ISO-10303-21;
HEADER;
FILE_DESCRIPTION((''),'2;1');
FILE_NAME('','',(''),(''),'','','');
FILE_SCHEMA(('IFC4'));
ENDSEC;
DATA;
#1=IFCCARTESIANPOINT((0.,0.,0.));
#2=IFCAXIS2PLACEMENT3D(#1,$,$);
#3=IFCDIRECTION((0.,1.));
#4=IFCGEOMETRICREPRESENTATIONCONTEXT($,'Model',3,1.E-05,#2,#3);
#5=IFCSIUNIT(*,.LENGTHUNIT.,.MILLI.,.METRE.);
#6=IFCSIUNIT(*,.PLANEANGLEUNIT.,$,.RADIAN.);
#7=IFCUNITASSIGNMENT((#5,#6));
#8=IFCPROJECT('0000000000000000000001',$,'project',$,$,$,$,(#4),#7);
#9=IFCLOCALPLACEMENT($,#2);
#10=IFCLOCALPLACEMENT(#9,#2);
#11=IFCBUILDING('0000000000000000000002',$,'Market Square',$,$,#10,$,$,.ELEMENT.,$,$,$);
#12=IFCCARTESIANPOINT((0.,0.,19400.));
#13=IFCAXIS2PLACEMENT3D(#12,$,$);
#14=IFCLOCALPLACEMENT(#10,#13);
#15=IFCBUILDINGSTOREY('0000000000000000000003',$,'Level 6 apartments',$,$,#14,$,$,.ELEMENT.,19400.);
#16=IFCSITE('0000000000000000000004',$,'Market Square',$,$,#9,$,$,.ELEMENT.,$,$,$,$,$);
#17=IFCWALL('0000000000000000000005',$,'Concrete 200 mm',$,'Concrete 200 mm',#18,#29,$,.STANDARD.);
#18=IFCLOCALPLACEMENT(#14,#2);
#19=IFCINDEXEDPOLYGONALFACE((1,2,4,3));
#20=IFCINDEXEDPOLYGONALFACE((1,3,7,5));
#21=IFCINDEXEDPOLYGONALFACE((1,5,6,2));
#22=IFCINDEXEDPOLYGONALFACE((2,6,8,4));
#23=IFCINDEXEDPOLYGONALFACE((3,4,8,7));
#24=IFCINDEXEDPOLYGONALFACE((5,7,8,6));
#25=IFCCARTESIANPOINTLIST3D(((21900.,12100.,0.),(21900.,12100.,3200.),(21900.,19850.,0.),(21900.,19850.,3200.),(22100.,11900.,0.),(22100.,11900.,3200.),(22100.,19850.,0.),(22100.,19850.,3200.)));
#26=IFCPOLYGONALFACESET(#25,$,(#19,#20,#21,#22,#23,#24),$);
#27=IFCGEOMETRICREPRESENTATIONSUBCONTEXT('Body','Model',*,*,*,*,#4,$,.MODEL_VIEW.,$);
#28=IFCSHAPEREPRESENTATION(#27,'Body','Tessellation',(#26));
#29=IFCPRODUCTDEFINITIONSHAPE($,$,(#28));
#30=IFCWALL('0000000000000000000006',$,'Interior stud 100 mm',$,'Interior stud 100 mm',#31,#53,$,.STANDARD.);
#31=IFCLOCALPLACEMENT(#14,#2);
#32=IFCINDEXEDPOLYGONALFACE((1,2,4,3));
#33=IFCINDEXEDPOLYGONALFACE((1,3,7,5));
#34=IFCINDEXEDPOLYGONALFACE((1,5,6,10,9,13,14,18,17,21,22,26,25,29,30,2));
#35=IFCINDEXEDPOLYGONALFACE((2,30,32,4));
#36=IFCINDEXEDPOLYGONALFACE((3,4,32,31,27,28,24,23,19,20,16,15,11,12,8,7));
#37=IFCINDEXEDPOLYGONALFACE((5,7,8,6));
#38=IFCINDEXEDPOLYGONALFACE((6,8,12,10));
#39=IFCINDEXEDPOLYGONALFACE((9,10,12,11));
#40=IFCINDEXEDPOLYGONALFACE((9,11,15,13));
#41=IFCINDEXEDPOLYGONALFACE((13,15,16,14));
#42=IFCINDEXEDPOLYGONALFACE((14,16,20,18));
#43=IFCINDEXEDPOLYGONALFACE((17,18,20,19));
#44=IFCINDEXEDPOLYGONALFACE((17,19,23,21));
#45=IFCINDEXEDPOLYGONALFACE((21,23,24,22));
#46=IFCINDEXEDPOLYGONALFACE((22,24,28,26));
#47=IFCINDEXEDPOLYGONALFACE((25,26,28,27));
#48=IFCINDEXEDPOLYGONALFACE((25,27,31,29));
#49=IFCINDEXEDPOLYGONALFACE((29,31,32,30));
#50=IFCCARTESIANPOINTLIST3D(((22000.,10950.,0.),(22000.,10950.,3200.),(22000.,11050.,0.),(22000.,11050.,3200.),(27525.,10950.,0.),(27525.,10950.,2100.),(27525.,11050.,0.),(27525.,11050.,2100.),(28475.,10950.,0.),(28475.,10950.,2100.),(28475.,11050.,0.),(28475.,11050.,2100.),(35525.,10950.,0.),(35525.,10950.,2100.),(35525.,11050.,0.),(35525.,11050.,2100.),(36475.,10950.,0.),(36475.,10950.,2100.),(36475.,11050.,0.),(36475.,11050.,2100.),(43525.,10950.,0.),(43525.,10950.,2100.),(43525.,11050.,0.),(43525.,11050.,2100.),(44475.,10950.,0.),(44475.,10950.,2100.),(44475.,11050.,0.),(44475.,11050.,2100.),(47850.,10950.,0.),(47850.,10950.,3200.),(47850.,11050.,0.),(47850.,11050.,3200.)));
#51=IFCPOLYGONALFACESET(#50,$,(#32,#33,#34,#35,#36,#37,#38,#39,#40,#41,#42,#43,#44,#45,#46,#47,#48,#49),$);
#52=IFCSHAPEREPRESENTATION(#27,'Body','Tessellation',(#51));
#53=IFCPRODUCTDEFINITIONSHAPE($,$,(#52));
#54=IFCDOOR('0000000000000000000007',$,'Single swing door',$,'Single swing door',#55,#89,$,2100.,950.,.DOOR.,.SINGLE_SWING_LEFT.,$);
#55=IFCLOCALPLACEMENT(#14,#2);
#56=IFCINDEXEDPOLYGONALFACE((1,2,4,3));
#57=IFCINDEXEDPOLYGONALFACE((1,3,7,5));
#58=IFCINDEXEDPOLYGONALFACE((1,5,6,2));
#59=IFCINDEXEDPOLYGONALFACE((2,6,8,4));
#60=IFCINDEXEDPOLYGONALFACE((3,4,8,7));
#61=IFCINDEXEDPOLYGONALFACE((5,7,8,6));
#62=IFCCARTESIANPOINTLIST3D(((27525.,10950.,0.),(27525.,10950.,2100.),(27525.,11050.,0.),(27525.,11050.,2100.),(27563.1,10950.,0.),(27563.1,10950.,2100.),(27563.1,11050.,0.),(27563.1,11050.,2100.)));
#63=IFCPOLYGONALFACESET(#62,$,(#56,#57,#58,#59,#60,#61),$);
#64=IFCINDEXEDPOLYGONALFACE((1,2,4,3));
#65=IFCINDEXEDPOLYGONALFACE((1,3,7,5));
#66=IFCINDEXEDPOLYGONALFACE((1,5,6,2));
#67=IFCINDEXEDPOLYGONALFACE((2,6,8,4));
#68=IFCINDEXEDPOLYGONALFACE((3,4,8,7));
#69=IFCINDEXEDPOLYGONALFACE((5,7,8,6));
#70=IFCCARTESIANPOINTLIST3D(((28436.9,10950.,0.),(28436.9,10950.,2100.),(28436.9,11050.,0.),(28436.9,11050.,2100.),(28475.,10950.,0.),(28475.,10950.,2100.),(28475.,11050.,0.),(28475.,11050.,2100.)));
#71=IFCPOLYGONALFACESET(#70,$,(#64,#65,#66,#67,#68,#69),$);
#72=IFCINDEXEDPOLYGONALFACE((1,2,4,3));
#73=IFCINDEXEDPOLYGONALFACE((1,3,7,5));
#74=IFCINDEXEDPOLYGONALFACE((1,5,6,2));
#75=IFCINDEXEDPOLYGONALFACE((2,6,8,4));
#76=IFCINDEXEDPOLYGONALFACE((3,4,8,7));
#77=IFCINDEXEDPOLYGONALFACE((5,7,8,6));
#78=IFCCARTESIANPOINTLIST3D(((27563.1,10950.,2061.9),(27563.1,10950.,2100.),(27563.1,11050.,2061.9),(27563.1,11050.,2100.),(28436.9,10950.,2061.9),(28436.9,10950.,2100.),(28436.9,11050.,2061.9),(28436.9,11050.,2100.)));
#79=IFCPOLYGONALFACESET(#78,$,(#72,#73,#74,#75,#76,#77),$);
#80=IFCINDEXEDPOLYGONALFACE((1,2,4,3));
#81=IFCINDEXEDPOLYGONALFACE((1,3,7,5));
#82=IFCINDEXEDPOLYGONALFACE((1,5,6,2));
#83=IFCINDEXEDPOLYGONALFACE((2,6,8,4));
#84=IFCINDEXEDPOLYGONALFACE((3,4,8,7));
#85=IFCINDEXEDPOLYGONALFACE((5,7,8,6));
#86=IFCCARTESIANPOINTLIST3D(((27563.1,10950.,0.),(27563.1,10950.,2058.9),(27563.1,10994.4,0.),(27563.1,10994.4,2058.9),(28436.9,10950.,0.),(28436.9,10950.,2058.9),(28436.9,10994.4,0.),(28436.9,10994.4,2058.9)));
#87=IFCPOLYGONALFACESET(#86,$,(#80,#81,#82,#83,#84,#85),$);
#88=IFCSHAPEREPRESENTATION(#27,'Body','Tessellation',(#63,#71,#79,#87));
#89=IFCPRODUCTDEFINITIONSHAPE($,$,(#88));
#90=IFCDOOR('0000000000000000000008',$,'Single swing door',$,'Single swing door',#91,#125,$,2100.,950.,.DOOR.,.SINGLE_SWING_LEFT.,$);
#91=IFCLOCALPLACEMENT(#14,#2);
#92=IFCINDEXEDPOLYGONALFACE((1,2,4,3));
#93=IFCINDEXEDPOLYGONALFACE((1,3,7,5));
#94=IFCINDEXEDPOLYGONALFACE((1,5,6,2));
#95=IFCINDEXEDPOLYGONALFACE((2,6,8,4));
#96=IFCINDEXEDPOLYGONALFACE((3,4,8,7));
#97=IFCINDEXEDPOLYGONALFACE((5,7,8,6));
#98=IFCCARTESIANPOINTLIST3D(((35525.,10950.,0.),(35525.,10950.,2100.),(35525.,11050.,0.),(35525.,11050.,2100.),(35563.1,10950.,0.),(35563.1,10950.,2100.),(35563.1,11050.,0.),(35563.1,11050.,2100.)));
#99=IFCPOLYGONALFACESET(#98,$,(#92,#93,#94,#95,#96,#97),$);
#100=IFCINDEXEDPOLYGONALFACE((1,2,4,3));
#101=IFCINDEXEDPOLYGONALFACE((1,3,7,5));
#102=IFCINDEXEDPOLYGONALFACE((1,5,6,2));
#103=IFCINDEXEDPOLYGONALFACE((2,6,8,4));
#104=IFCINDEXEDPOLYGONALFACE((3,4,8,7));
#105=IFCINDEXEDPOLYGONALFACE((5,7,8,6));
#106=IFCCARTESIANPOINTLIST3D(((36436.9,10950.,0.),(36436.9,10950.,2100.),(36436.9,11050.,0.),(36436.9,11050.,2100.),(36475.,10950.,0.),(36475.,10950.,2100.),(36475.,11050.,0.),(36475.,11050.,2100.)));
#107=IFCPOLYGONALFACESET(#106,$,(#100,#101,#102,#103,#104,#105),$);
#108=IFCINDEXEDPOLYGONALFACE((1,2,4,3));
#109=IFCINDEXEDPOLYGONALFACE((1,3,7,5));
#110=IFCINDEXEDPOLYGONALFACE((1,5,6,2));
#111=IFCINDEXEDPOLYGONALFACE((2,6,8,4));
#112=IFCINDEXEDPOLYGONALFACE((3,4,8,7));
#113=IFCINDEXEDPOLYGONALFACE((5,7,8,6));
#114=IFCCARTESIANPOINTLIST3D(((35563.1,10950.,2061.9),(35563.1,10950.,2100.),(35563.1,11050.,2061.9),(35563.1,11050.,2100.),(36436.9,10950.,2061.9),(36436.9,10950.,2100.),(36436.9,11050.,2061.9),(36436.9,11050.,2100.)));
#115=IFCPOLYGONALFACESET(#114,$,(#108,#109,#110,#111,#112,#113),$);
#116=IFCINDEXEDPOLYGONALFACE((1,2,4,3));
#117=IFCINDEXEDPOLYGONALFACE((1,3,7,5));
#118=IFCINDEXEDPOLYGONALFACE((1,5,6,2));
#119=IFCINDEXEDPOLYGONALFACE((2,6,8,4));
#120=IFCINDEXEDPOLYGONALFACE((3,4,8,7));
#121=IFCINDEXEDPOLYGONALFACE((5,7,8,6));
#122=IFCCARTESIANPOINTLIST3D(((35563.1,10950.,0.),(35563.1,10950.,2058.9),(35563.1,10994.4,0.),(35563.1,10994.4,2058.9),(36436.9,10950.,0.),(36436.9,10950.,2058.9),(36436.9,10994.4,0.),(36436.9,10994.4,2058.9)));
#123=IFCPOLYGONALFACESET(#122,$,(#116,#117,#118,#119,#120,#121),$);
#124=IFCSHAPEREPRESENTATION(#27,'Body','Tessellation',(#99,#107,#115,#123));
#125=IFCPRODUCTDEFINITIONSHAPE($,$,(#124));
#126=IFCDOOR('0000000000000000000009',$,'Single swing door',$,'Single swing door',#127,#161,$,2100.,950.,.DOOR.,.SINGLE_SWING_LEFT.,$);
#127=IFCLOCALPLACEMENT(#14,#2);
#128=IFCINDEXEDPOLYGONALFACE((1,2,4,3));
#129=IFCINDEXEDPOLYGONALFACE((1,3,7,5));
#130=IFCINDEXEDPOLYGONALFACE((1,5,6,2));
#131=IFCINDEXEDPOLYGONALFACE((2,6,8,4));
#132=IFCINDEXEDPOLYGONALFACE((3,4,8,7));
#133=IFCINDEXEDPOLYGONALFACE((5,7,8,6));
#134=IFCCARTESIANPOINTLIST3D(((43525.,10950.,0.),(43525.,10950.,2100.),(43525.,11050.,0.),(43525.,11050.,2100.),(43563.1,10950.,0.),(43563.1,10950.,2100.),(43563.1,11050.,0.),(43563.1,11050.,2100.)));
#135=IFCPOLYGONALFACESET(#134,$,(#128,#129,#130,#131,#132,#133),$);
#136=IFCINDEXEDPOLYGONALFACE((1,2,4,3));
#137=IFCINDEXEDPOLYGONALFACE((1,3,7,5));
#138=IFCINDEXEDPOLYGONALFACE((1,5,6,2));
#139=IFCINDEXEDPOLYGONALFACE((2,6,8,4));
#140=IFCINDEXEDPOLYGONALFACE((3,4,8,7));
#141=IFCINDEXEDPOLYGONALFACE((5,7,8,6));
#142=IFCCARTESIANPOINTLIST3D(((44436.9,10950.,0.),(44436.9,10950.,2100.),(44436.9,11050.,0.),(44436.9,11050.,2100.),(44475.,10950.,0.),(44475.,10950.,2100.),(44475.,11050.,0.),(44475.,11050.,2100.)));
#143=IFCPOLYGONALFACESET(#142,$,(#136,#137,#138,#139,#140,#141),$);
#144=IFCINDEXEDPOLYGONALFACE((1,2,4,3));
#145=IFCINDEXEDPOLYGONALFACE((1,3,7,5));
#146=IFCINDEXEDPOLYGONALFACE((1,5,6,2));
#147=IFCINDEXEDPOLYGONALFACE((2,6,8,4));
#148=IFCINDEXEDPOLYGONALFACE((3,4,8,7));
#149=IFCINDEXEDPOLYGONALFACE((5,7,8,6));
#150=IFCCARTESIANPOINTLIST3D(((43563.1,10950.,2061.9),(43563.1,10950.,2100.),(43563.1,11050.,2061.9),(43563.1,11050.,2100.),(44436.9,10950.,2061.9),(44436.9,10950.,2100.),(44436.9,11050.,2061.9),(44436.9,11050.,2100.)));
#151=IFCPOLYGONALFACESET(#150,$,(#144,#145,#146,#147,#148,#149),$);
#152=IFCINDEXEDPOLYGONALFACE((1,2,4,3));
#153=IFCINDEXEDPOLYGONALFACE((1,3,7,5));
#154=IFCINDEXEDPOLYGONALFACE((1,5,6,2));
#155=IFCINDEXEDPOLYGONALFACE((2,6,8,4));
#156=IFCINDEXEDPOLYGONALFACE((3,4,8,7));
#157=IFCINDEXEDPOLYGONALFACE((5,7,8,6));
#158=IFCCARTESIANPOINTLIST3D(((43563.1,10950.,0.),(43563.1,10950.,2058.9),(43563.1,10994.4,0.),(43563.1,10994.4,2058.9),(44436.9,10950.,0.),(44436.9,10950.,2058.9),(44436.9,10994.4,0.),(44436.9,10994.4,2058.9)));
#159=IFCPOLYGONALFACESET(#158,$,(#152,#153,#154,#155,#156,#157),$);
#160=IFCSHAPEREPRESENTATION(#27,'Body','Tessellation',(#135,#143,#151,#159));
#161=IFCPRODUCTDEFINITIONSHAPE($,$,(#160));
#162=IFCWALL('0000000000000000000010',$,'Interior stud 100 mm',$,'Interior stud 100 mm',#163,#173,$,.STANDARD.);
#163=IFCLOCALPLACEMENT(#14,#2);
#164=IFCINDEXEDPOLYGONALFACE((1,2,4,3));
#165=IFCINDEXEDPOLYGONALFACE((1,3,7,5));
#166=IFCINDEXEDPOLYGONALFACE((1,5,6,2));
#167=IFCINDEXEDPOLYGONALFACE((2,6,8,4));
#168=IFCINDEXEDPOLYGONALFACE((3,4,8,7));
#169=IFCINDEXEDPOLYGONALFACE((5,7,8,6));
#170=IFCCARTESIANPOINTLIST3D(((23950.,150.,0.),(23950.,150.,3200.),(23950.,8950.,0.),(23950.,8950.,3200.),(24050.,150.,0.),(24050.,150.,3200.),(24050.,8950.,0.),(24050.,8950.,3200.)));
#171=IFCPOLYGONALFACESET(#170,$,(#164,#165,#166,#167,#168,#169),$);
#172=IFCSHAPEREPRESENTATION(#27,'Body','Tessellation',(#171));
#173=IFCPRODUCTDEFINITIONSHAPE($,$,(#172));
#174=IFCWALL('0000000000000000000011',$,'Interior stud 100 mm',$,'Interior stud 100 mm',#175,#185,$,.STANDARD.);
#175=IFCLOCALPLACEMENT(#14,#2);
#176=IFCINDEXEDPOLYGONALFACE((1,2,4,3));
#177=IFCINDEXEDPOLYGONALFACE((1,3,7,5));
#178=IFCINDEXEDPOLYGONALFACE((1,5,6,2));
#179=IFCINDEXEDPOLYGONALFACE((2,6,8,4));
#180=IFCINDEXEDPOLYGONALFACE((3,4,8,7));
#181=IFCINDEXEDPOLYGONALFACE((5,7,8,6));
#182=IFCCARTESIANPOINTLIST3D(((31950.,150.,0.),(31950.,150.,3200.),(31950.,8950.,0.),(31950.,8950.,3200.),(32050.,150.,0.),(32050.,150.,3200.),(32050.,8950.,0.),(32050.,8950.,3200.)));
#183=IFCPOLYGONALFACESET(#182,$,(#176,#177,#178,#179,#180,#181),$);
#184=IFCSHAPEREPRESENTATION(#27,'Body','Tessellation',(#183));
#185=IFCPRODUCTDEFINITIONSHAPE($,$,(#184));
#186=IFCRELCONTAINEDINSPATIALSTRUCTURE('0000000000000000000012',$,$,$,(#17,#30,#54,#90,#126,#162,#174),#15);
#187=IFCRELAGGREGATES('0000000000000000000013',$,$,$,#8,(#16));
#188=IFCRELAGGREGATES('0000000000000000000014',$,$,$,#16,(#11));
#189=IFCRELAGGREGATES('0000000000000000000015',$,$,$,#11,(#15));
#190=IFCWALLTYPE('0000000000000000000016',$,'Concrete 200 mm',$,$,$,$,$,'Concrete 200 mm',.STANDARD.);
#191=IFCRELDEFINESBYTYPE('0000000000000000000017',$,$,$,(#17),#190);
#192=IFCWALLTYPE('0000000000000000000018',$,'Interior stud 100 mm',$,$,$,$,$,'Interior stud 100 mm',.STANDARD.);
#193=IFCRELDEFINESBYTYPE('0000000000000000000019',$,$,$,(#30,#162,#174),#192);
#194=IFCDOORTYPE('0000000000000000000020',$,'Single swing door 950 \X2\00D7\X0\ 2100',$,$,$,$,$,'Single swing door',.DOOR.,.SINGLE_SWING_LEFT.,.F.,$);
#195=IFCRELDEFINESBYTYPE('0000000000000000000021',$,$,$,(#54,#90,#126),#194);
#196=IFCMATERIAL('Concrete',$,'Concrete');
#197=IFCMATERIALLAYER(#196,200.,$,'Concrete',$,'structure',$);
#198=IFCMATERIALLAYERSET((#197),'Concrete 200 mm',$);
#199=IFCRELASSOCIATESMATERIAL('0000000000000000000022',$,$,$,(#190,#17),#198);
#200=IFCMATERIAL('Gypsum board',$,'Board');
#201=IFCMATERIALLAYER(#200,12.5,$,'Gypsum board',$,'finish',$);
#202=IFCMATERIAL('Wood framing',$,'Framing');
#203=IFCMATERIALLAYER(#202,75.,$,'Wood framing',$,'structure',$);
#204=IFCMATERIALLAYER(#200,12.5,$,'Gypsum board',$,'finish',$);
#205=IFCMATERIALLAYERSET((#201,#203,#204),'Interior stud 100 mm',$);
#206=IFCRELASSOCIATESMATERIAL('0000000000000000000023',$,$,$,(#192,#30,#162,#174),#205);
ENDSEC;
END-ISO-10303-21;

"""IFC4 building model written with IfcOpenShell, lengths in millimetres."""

from ifc_helpers import new_model, si_unit, direction, frame, origin, origin_with_axes, place, context, subcontext, project, spatial, polyline, outline, extrude, material, layer, layer_set, layer_usage, type_object, element, fill, save


model = new_model("IFC4")

# Units and contexts
model_context = context("Model", 3, precision=1e-05, world=origin(), true_north=direction((0.0, 1.0)))
body_context = subcontext(model_context, "Body", "Model", "MODEL_VIEW")
ifc_project = project(units=[si_unit("LENGTHUNIT", "METRE", prefix="MILLI"), si_unit("PLANEANGLEUNIT", "RADIAN")], contexts=[model_context])

# Site, building, storey
site_placement = place(None, origin())
site = spatial("IfcSite", under=ifc_project, at=site_placement, Name="Market Square", CompositionType="ELEMENT")
building_placement = place(site_placement, origin())
building = spatial("IfcBuilding", under=site, at=building_placement, Name="Market Square", CompositionType="ELEMENT")
storey_placement = place(building_placement, frame((0.0, 0.0, 19400.0)))
storey = spatial("IfcBuildingStorey", under=building, at=storey_placement, Name="Level 6 apartments", CompositionType="ELEMENT", Elevation=19400.0)

# Wall
ifc_material_1 = material(Name="Concrete", Category="Concrete")
ifc_layer_1 = layer(ifc_material_1, 200.0, Name="Concrete", Category="structure")
ifc_layer_set_1 = layer_set([ifc_layer_1], Name="Concrete 200 mm")
ifc_layer_usage_1 = layer_usage(ifc_layer_set_1, "AXIS2", "NEGATIVE", 100.0)
wall_type_1 = type_object("IfcWallType", Name="Concrete 200 mm", ElementType="Concrete 200 mm", PredefinedType="STANDARD", material=ifc_layer_set_1)
wall_1_placement = place(storey_placement, frame((22000.0, 12000.0, 0.0), z_axis=(0.0, 0.0, 1.0), x_axis=(0.0, 1.0, 0.0)))
element("IfcWall", 1, at=wall_1_placement, inside=storey, type_object=wall_type_1, material=ifc_layer_usage_1, Name="Concrete 200 mm", ObjectType="Concrete 200 mm", PredefinedType="STANDARD", context=body_context, shape_type="SweptSolid", body=[
    extrude(outline(polyline([(-100.0, -100.0), (7850.0, -100.0), (7850.0, 100.0), (100.0, 100.0), (-100.0, -100.0)])), origin(), (0.0, 0.0, 1.0), 3200.0),
])

# Wall, openings, doors
ifc_material_2 = material(Name="Gypsum board", Category="Board")
ifc_layer_2 = layer(ifc_material_2, 12.5, Name="Gypsum board", Category="finish")
ifc_material_3 = material(Name="Wood framing", Category="Framing")
ifc_layer_3 = layer(ifc_material_3, 75.0, Name="Wood framing", Category="structure")
ifc_layer_4 = layer(ifc_material_2, 12.5, Name="Gypsum board", Category="finish")
ifc_layer_set_2 = layer_set([ifc_layer_2, ifc_layer_3, ifc_layer_4], Name="Interior stud 100 mm")
ifc_layer_usage_2 = layer_usage(ifc_layer_set_2, "AXIS2", "NEGATIVE", 50.0)
wall_type_2 = type_object("IfcWallType", Name="Interior stud 100 mm", ElementType="Interior stud 100 mm", PredefinedType="STANDARD", material=ifc_layer_set_2)
wall_2_placement = place(storey_placement, frame((22000.0, 11000.0, 0.0), z_axis=(0.0, 0.0, 1.0), x_axis=(1.0, 0.0, 0.0)))
wall_2 = element("IfcWall", 2, at=wall_2_placement, inside=storey, type_object=wall_type_2, material=ifc_layer_usage_2, Name="Interior stud 100 mm", ObjectType="Interior stud 100 mm", PredefinedType="STANDARD", context=body_context, shape_type="SweptSolid", body=[
    extrude(outline(polyline([(0.0, -50.0), (25850.0, -50.0), (25850.0, 50.0), (0.0, 50.0), (0.0, -50.0)])), origin(), (0.0, 0.0, 1.0), 3200.0),
])
opening_1_placement = place(wall_2_placement, frame((5525.0, 0.0, 0.0), z_axis=(0.0, 0.0, 1.0), x_axis=(1.0, 0.0, 0.0)))
opening_1 = element("IfcOpeningElement", 3, at=opening_1_placement, cuts=wall_2, PredefinedType="OPENING", context=body_context, shape_type="SweptSolid", body=[
    extrude(outline(polyline([(0.0, -60.0), (950.0, -60.0), (950.0, 60.0), (0.0, 60.0), (0.0, -60.0)])), origin(), (0.0, 0.0, 1.0), 2100.0),
])
opening_2_placement = place(wall_2_placement, frame((13525.0, 0.0, 0.0), z_axis=(0.0, 0.0, 1.0), x_axis=(1.0, 0.0, 0.0)))
opening_2 = element("IfcOpeningElement", 4, at=opening_2_placement, cuts=wall_2, PredefinedType="OPENING", context=body_context, shape_type="SweptSolid", body=[
    extrude(outline(polyline([(0.0, -60.0), (950.0, -60.0), (950.0, 60.0), (0.0, 60.0), (0.0, -60.0)])), origin(), (0.0, 0.0, 1.0), 2100.0),
])
opening_3_placement = place(wall_2_placement, frame((21525.0, 0.0, 0.0), z_axis=(0.0, 0.0, 1.0), x_axis=(1.0, 0.0, 0.0)))
opening_3 = element("IfcOpeningElement", 5, at=opening_3_placement, cuts=wall_2, PredefinedType="OPENING", context=body_context, shape_type="SweptSolid", body=[
    extrude(outline(polyline([(0.0, -60.0), (950.0, -60.0), (950.0, 60.0), (0.0, 60.0), (0.0, -60.0)])), origin(), (0.0, 0.0, 1.0), 2100.0),
])
door_type = type_object("IfcDoorType", Name="Single swing door 950 × 2100", ElementType="Single swing door", OperationType="SINGLE_SWING_LEFT", ParameterTakesPrecedence=False, PredefinedType="DOOR")
door_1_placement = place(opening_1_placement, origin_with_axes())
door_1 = element("IfcDoor", 6, at=door_1_placement, inside=storey, type_object=door_type, Name="Single swing door", ObjectType="Single swing door", OperationType="SINGLE_SWING_LEFT", OverallHeight=2100.0, OverallWidth=950.0, PredefinedType="DOOR", context=body_context, shape_type="SweptSolid", body=[
    extrude(outline(polyline([(0.0, -50.0), (38.1, -50.0), (38.1, 50.0), (0.0, 50.0), (0.0, -50.0)])), origin(), (0.0, 0.0, 1.0), 2100.0),
    extrude(outline(polyline([(911.9, -50.0), (950.0, -50.0), (950.0, 50.0), (911.9, 50.0), (911.9, -50.0)])), origin(), (0.0, 0.0, 1.0), 2100.0),
    extrude(outline(polyline([(38.1, -50.0), (911.9, -50.0), (911.9, 50.0), (38.1, 50.0), (38.1, -50.0)])), frame((0.0, 0.0, 2061.9)), (0.0, 0.0, 1.0), 38.1),
    extrude(outline(polyline([(38.1, -50.0), (911.9, -50.0), (911.9, -5.5), (38.1, -5.5), (38.1, -50.0)])), origin(), (0.0, 0.0, 1.0), 2058.9),
])
fill(opening_1, door_1)
door_2_placement = place(opening_2_placement, origin_with_axes())
door_2 = element("IfcDoor", 7, at=door_2_placement, inside=storey, type_object=door_type, Name="Single swing door", ObjectType="Single swing door", OperationType="SINGLE_SWING_LEFT", OverallHeight=2100.0, OverallWidth=950.0, PredefinedType="DOOR", context=body_context, shape_type="SweptSolid", body=[
    extrude(outline(polyline([(0.0, -50.0), (38.1, -50.0), (38.1, 50.0), (0.0, 50.0), (0.0, -50.0)])), origin(), (0.0, 0.0, 1.0), 2100.0),
    extrude(outline(polyline([(911.9, -50.0), (950.0, -50.0), (950.0, 50.0), (911.9, 50.0), (911.9, -50.0)])), origin(), (0.0, 0.0, 1.0), 2100.0),
    extrude(outline(polyline([(38.1, -50.0), (911.9, -50.0), (911.9, 50.0), (38.1, 50.0), (38.1, -50.0)])), frame((0.0, 0.0, 2061.9)), (0.0, 0.0, 1.0), 38.1),
    extrude(outline(polyline([(38.1, -50.0), (911.9, -50.0), (911.9, -5.5), (38.1, -5.5), (38.1, -50.0)])), origin(), (0.0, 0.0, 1.0), 2058.9),
])
fill(opening_2, door_2)
door_3_placement = place(opening_3_placement, origin_with_axes())
door_3 = element("IfcDoor", 8, at=door_3_placement, inside=storey, type_object=door_type, Name="Single swing door", ObjectType="Single swing door", OperationType="SINGLE_SWING_LEFT", OverallHeight=2100.0, OverallWidth=950.0, PredefinedType="DOOR", context=body_context, shape_type="SweptSolid", body=[
    extrude(outline(polyline([(0.0, -50.0), (38.1, -50.0), (38.1, 50.0), (0.0, 50.0), (0.0, -50.0)])), origin(), (0.0, 0.0, 1.0), 2100.0),
    extrude(outline(polyline([(911.9, -50.0), (950.0, -50.0), (950.0, 50.0), (911.9, 50.0), (911.9, -50.0)])), origin(), (0.0, 0.0, 1.0), 2100.0),
    extrude(outline(polyline([(38.1, -50.0), (911.9, -50.0), (911.9, 50.0), (38.1, 50.0), (38.1, -50.0)])), frame((0.0, 0.0, 2061.9)), (0.0, 0.0, 1.0), 38.1),
    extrude(outline(polyline([(38.1, -50.0), (911.9, -50.0), (911.9, -5.5), (38.1, -5.5), (38.1, -50.0)])), origin(), (0.0, 0.0, 1.0), 2058.9),
])
fill(opening_3, door_3)

# Walls
ifc_layer_usage_3 = layer_usage(ifc_layer_set_2, "AXIS2", "NEGATIVE", 50.0)
wall_3_placement = place(storey_placement, frame((24000.0, 0.0, 0.0), z_axis=(0.0, 0.0, 1.0), x_axis=(0.0, 1.0, 0.0)))
element("IfcWall", 9, at=wall_3_placement, inside=storey, type_object=wall_type_2, material=ifc_layer_usage_3, Name="Interior stud 100 mm", ObjectType="Interior stud 100 mm", PredefinedType="STANDARD", context=body_context, shape_type="SweptSolid", body=[
    extrude(outline(polyline([(150.0, -50.0), (8950.0, -50.0), (8950.0, 50.0), (150.0, 50.0), (150.0, -50.0)])), origin(), (0.0, 0.0, 1.0), 3200.0),
])
ifc_layer_usage_4 = layer_usage(ifc_layer_set_2, "AXIS2", "NEGATIVE", 50.0)
wall_4_placement = place(storey_placement, frame((32000.0, 0.0, 0.0), z_axis=(0.0, 0.0, 1.0), x_axis=(0.0, 1.0, 0.0)))
element("IfcWall", 10, at=wall_4_placement, inside=storey, type_object=wall_type_2, material=ifc_layer_usage_4, Name="Interior stud 100 mm", ObjectType="Interior stud 100 mm", PredefinedType="STANDARD", context=body_context, shape_type="SweptSolid", body=[
    extrude(outline(polyline([(150.0, -50.0), (8950.0, -50.0), (8950.0, 50.0), (150.0, 50.0), (150.0, -50.0)])), origin(), (0.0, 0.0, 1.0), 3200.0),
])

save(model, "model.ifc")
